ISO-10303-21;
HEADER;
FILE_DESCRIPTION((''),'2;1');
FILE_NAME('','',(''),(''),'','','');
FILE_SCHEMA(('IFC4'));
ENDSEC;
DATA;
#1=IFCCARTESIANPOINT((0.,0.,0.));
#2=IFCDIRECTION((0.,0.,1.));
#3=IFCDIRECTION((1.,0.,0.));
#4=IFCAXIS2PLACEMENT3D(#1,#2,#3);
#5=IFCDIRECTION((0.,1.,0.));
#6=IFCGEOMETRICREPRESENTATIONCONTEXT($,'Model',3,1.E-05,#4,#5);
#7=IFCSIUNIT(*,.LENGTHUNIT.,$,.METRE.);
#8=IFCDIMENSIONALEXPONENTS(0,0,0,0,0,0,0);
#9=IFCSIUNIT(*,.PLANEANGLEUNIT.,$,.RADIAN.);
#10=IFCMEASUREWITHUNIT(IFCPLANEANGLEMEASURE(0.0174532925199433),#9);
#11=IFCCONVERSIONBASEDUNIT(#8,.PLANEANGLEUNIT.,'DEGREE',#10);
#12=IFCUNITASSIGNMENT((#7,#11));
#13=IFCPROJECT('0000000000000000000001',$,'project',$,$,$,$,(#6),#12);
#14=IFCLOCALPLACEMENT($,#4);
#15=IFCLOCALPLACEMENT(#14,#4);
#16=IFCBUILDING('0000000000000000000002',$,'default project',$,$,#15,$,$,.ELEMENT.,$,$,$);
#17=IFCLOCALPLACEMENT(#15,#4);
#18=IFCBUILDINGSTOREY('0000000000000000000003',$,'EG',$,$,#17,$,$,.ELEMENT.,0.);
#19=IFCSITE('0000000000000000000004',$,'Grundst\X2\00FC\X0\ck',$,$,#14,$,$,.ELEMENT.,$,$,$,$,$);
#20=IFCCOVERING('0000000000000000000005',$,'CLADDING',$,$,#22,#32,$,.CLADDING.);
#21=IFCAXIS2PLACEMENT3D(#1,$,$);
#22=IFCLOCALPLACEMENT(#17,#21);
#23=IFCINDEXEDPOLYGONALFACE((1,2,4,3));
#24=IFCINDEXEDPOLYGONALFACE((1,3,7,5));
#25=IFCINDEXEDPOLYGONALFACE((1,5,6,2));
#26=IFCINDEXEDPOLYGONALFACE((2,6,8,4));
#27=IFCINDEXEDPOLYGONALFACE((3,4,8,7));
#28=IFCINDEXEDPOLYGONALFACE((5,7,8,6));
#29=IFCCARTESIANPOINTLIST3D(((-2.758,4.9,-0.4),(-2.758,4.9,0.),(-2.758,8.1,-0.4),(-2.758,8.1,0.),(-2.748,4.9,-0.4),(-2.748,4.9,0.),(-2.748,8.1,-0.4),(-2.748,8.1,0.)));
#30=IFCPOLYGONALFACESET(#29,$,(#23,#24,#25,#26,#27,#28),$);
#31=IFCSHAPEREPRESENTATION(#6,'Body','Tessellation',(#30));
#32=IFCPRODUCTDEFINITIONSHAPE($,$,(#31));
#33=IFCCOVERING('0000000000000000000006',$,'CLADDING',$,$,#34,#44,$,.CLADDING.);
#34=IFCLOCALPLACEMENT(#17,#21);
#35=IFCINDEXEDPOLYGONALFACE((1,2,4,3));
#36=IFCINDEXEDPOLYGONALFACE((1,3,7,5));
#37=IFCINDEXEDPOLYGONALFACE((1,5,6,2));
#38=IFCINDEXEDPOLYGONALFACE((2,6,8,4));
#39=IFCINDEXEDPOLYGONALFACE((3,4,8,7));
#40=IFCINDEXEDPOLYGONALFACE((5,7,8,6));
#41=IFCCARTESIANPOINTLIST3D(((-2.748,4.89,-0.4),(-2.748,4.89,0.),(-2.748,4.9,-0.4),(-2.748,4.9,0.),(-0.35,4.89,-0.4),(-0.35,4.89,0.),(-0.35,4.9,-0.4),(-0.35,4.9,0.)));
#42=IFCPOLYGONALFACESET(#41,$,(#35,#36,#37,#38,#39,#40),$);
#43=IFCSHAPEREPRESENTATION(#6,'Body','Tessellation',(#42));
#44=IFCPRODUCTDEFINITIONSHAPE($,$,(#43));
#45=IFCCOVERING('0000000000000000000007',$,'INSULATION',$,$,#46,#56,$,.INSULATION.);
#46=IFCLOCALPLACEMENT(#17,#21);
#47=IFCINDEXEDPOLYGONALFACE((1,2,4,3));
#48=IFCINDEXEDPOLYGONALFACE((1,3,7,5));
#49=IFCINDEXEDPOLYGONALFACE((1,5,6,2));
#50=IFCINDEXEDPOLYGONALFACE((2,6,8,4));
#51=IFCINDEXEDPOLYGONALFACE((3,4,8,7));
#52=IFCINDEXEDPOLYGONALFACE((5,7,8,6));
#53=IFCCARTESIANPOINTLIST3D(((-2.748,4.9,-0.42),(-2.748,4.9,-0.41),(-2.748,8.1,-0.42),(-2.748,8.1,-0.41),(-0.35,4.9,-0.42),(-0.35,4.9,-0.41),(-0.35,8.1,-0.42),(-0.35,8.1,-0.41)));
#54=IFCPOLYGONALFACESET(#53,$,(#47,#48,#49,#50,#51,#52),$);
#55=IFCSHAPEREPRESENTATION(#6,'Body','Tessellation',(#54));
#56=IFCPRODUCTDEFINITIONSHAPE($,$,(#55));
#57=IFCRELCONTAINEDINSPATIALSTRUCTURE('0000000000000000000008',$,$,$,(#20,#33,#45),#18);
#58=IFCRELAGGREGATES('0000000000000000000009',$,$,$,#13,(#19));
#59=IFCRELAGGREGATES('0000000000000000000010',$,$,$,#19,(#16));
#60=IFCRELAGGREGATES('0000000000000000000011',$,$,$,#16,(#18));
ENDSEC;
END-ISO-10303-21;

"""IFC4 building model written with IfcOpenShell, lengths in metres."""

from ifc_helpers import new_model, entity, si_unit, converted_unit, direction, frame, origin_with_axes, place, context, project, spatial, polyline, outline, extrude, element, save


model = new_model("IFC4")

# Units and contexts
model_context = context("Model", 3, precision=1e-05, world=origin_with_axes(), true_north=direction((0.0, 1.0, 0.0)))
ifc_project = project(units=[si_unit("LENGTHUNIT", "METRE"), converted_unit("PLANEANGLEUNIT", "DEGREE", entity("IfcPlaneAngleMeasure", 0.0174532925199433), si_unit("PLANEANGLEUNIT", "RADIAN"), dimensions=[0, 0, 0, 0, 0, 0, 0])], contexts=[model_context])

# Site, building, storey
site_placement = place(None, origin_with_axes())
site = spatial("IfcSite", under=ifc_project, at=site_placement, Name="Grundstück", CompositionType="ELEMENT")
building_placement = place(site_placement, origin_with_axes())
building = spatial("IfcBuilding", under=site, at=building_placement, Name="default project", CompositionType="ELEMENT")
placement_1 = place(building_placement, origin_with_axes())
storey = spatial("IfcBuildingStorey", under=building, at=placement_1, Name="EG", CompositionType="ELEMENT", Elevation=0.0)

# Shared definitions
slab_1_placement = place(placement_1, frame((0.0, 0.0, -0.4), z_axis=(0.0, 0.0, 1.0), x_axis=(1.0, 0.0, 0.0)))
slab_2_placement = place(placement_1, frame((0.0, 0.0, -0.4), z_axis=(0.0, 0.0, 1.0), x_axis=(1.0, 0.0, 0.0)))

# Coverings
covering_1_placement = place(slab_2_placement, origin_with_axes())
element("IfcCovering", 1, at=covering_1_placement, inside=storey, Name="CLADDING", PredefinedType="CLADDING", context=model_context, shape_type="SweptSolid", body=[
    extrude(outline(polyline([(-2.758, 8.1), (-2.758, 4.9), (-2.748, 4.9), (-2.748, 8.1), (-2.758, 8.1)])), origin_with_axes(), (0.0, 0.0, 1.0), 0.4),
])
covering_2_placement = place(slab_2_placement, origin_with_axes())
element("IfcCovering", 2, at=covering_2_placement, inside=storey, Name="CLADDING", PredefinedType="CLADDING", context=model_context, shape_type="SweptSolid", body=[
    extrude(outline(polyline([(-2.748, 4.89), (-0.35, 4.89), (-0.35, 4.9), (-2.748, 4.9), (-2.748, 4.89)])), origin_with_axes(), (0.0, 0.0, 1.0), 0.4),
])
covering_3_placement = place(slab_1_placement, frame((0.0, 0.0, -0.01), z_axis=(0.0, 0.0, 1.0), x_axis=(1.0, 0.0, 0.0)))
element("IfcCovering", 3, at=covering_3_placement, inside=storey, Name="INSULATION", PredefinedType="INSULATION", context=model_context, shape_type="SweptSolid", body=[
    extrude(outline(polyline([(-0.35, 8.1), (-2.748, 8.1), (-2.748, 4.9), (-0.35, 4.9), (-0.35, 8.1)])), frame((0.0, 0.0, -0.01), z_axis=(0.0, 0.0, 1.0), x_axis=(1.0, 0.0, 0.0)), (0.0, 0.0, 1.0), 0.01),
])

save(model, "model.ifc")
